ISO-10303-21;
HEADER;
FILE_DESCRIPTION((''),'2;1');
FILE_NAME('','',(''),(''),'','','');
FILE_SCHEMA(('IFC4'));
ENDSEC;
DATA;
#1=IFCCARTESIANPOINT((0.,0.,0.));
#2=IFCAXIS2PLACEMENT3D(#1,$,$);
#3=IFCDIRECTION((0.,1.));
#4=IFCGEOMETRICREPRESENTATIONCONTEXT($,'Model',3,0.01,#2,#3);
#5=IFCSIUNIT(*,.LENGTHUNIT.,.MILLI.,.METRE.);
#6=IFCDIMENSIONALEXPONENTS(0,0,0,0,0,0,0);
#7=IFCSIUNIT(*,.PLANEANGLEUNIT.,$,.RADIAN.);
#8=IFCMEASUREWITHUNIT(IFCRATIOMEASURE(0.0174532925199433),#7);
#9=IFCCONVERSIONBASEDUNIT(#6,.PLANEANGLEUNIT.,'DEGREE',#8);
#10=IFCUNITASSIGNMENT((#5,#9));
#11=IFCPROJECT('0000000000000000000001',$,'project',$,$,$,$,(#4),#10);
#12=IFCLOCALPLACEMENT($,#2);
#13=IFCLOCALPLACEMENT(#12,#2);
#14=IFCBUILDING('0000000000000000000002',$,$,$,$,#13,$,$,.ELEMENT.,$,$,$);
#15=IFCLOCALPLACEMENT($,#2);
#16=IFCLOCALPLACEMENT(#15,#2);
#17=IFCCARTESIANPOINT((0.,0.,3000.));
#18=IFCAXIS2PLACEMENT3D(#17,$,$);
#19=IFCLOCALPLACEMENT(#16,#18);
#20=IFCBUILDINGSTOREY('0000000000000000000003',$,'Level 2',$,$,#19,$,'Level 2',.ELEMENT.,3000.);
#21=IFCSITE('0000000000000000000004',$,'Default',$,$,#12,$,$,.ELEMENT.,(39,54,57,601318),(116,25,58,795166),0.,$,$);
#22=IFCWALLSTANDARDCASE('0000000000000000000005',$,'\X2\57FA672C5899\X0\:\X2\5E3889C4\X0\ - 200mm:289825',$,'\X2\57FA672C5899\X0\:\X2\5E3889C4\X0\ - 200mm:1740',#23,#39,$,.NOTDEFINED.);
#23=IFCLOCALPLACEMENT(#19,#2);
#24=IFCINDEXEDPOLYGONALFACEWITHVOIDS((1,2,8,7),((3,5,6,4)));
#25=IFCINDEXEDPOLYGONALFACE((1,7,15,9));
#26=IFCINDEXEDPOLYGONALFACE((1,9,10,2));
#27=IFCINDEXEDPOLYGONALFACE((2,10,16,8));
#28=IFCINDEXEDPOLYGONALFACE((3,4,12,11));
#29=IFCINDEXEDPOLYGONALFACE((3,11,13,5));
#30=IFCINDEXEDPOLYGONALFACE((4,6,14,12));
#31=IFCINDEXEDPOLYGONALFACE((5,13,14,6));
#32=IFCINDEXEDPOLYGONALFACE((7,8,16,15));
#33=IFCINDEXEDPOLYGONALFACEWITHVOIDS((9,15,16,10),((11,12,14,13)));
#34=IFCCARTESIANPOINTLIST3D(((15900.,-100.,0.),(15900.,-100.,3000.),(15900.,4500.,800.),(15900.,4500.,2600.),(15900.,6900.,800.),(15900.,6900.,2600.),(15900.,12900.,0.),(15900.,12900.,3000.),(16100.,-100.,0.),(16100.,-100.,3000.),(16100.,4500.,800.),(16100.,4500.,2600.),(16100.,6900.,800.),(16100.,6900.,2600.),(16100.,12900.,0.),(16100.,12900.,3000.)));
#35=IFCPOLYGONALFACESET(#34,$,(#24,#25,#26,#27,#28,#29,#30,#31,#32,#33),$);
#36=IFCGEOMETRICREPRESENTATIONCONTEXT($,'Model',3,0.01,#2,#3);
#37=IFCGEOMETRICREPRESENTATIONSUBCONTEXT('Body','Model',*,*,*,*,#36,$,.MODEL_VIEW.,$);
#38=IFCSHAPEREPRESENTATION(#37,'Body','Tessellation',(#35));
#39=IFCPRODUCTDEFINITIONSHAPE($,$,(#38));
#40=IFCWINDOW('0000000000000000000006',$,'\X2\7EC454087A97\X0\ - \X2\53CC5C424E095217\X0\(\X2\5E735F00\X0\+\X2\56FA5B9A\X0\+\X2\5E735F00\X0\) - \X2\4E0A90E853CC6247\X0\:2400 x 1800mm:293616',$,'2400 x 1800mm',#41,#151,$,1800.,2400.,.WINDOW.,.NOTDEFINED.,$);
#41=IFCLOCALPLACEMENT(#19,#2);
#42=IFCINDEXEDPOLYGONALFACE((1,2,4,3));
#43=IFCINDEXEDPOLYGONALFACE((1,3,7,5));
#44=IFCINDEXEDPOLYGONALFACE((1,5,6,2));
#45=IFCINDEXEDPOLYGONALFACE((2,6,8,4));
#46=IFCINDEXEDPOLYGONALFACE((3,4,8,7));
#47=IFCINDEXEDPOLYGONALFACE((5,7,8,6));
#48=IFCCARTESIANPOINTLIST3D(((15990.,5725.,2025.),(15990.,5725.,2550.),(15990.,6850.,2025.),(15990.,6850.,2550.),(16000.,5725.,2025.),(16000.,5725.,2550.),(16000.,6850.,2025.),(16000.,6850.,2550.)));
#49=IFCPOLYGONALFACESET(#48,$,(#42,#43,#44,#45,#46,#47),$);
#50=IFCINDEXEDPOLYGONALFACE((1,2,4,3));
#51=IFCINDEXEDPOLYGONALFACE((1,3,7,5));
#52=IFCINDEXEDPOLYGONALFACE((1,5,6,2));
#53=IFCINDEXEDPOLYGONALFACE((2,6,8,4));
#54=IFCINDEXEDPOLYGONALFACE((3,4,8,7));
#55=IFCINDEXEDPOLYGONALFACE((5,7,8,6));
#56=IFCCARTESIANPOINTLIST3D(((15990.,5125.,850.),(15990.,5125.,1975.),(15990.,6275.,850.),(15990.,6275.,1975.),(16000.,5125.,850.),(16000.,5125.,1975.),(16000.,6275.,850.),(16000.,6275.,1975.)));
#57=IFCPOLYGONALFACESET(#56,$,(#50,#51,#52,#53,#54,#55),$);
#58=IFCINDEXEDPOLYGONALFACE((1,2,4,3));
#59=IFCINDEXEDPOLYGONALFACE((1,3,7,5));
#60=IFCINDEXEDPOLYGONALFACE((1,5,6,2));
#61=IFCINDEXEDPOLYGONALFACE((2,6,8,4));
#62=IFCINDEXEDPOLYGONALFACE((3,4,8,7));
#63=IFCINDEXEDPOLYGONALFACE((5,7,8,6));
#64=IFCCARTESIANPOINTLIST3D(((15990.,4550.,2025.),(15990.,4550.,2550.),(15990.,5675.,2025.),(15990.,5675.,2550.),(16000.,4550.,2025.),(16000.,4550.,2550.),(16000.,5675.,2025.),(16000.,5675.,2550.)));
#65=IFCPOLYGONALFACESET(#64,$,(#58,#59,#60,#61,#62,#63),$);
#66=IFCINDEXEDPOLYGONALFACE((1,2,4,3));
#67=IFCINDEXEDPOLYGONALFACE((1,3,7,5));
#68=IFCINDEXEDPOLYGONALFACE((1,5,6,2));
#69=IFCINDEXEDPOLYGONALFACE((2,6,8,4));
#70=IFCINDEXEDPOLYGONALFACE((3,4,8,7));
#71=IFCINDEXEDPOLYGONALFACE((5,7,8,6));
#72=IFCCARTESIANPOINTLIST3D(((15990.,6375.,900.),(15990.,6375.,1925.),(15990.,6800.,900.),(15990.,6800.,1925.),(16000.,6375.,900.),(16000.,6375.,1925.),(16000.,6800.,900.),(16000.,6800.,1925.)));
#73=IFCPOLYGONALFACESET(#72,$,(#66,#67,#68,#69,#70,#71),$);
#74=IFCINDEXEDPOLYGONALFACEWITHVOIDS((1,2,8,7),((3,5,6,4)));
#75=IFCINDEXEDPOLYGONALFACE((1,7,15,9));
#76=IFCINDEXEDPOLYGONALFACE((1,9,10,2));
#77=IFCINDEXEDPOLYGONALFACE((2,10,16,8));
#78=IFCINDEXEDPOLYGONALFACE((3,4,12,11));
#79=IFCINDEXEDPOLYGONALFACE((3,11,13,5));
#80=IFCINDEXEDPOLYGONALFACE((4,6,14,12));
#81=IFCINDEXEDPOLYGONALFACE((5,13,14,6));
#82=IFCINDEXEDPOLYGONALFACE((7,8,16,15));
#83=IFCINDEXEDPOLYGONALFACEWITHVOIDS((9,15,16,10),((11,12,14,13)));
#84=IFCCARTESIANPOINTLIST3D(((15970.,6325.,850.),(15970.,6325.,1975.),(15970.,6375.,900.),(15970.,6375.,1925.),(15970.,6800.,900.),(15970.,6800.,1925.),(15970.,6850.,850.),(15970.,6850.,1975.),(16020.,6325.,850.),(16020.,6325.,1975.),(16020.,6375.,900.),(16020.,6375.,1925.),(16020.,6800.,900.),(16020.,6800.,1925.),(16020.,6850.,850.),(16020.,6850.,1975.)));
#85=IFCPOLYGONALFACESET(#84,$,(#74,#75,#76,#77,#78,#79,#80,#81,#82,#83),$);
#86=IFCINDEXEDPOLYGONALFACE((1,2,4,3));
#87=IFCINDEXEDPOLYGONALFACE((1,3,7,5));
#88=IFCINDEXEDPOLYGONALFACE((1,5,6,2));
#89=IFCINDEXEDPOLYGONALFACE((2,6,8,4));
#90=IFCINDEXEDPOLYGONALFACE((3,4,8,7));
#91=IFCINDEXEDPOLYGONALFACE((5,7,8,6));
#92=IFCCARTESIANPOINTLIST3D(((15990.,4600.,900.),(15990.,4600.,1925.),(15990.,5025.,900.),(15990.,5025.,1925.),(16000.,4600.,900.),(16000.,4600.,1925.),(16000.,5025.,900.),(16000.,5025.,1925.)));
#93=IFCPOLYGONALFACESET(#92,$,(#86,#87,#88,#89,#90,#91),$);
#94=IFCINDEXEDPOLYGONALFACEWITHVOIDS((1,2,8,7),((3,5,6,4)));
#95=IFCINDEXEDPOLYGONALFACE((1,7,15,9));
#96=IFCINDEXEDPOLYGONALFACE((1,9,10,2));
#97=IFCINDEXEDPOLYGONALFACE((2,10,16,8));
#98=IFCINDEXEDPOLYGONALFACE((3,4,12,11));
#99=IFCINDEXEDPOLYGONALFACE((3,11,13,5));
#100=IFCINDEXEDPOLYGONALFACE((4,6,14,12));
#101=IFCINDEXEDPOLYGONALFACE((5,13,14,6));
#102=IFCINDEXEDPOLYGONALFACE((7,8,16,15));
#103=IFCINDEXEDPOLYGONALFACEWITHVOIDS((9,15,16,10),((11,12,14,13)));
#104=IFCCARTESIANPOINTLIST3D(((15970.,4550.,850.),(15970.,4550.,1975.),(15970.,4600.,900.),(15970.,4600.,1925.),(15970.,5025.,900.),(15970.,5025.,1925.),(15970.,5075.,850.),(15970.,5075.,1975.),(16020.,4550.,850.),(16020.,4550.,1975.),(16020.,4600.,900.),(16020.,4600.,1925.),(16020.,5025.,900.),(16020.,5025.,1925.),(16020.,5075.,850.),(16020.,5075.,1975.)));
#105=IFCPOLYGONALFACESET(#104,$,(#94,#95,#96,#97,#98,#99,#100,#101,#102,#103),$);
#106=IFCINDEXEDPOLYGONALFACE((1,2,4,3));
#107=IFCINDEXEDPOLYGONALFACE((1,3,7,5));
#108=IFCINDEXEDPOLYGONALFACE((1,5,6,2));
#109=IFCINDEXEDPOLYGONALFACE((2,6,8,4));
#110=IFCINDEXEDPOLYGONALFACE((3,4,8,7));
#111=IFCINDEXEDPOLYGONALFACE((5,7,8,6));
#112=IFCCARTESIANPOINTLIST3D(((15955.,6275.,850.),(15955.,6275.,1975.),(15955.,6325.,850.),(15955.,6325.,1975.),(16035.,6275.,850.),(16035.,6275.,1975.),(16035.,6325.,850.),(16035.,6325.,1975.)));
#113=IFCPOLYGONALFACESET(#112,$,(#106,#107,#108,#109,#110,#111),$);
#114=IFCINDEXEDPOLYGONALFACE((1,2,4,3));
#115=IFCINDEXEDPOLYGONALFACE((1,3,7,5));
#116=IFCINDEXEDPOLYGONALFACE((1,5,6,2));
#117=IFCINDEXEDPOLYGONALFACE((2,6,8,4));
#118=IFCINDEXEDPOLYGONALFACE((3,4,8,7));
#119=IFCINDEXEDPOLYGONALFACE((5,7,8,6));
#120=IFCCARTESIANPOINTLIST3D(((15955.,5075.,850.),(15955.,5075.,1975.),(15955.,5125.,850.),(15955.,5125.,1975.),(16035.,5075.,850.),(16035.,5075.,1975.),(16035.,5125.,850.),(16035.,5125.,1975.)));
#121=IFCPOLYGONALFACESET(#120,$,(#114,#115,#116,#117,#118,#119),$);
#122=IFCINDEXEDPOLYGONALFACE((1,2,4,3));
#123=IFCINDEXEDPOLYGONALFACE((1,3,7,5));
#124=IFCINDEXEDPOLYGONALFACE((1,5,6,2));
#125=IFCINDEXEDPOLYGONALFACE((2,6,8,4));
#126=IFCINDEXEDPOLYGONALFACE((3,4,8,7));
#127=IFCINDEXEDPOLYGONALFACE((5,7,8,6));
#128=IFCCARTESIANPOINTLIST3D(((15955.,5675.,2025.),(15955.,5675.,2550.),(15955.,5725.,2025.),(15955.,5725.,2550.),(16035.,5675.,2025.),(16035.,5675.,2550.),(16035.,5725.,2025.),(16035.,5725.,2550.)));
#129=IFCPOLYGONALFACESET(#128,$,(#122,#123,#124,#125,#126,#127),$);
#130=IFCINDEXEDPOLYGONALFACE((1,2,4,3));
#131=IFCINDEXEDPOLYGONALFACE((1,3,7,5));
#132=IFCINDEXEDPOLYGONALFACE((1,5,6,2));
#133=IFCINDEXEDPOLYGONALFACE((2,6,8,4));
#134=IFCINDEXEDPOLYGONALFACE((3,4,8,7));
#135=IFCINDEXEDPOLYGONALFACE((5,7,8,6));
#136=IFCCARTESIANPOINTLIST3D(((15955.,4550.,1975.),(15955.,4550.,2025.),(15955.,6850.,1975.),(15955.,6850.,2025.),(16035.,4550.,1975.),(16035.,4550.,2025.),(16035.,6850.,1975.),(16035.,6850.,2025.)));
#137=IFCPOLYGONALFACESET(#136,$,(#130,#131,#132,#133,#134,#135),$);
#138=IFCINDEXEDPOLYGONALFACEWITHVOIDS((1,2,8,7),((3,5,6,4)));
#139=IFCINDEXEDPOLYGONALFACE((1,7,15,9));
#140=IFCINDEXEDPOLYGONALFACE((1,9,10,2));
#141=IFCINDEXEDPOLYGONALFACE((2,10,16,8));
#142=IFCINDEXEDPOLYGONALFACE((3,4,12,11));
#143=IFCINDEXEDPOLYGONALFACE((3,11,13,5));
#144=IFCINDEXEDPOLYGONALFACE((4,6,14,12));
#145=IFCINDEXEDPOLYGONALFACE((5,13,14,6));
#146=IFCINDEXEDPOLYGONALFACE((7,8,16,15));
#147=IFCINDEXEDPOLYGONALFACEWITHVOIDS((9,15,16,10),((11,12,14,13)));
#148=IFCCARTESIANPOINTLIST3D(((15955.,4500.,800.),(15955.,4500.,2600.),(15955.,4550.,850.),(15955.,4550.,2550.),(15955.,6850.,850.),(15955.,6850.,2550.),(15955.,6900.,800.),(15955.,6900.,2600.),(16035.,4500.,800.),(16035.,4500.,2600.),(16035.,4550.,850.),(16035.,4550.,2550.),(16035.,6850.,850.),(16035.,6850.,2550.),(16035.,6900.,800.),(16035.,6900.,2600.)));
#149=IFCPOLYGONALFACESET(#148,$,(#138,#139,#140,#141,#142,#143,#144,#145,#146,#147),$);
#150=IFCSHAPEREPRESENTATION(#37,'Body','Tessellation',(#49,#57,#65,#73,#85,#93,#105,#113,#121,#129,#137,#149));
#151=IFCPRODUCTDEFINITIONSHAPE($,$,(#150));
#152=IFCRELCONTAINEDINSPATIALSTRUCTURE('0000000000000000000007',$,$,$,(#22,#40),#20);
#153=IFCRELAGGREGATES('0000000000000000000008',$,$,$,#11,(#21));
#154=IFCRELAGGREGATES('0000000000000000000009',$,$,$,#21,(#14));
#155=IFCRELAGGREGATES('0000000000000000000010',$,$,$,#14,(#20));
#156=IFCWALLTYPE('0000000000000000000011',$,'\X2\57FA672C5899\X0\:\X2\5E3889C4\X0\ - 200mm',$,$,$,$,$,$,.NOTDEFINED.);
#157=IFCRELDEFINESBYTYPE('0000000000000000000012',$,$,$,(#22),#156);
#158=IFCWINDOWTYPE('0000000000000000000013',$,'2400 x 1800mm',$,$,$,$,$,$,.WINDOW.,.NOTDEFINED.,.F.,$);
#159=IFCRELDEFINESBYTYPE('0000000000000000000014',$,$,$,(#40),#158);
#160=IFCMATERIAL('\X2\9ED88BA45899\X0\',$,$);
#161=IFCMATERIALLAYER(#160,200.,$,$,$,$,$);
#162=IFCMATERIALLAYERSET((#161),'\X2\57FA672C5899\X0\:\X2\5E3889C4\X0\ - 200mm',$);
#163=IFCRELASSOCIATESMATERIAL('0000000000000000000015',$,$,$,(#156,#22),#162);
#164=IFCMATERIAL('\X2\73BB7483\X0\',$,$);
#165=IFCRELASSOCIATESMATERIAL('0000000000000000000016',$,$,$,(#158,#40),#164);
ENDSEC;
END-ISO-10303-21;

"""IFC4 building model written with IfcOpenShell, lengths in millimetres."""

from ifc_helpers import new_model, entity, si_unit, converted_unit, direction, frame, frame_2d, origin, origin_2d_with_axis, place, context, subcontext, project, spatial, polyline, rectangle, outline, extrude, source, transform, mapped, material, layer, layer_set, layer_usage, type_object, type_shapes, element, fill, save


model = new_model("IFC4")

# Units and contexts
model_context_1 = context("Model", 3, precision=0.01, world=origin(), true_north=direction((0.0, 1.0)))
model_context_2 = context("Model", 3, precision=0.01, world=origin(), true_north=direction((0.0, 1.0)))
body_context = subcontext(model_context_2, "Body", "Model", "MODEL_VIEW")
ifc_project = project(units=[si_unit("LENGTHUNIT", "METRE", prefix="MILLI"), converted_unit("PLANEANGLEUNIT", "DEGREE", entity("IfcRatioMeasure", 0.0174532925199433), si_unit("PLANEANGLEUNIT", "RADIAN"), dimensions=[0, 0, 0, 0, 0, 0, 0])], contexts=[model_context_1])

# Site, building, storey
site_placement = place(None, origin())
site = spatial("IfcSite", under=ifc_project, at=site_placement, Name="Default", CompositionType="ELEMENT", RefLatitude=(39, 54, 57, 601318), RefLongitude=(116, 25, 58, 795166), RefElevation=0.0)
building_placement = place(site_placement, origin())
building = spatial("IfcBuilding", under=site, at=building_placement, CompositionType="ELEMENT")
placement_1 = place(None, origin())
placement_2 = place(placement_1, origin())
storey_placement = place(placement_2, frame((0.0, 0.0, 3000.0)))
storey = spatial("IfcBuildingStorey", under=building, at=storey_placement, Name="Level 2", LongName="Level 2", CompositionType="ELEMENT", Elevation=3000.0)

# Shared definitions
ifc_material_1 = material(Name="默认墙")
ifc_layer = layer(ifc_material_1, 200.0)
ifc_layer_set = layer_set([ifc_layer], Name="基本墙:常规 - 200mm")
wall_type = type_object("IfcWallType", Name="基本墙:常规 - 200mm", PredefinedType="NOTDEFINED", material=ifc_layer_set)

# Wall, opening, window
ifc_layer_usage_1 = layer_usage(ifc_layer_set, "AXIS2", "NEGATIVE", 100.0)
wall_1_placement = place(storey_placement, frame((16000.0, 12900.0, 0.0), z_axis=(0.0, 0.0, 1.0), x_axis=(0.0, -1.0, 0.0)))
wall_1 = element("IfcWallStandardCase", 1, at=wall_1_placement, inside=storey, type_object=wall_type, material=ifc_layer_usage_1, Name="基本墙:常规 - 200mm:289825", ObjectType="基本墙:常规 - 200mm:1740", PredefinedType="NOTDEFINED", context=body_context, shape_type="SweptSolid", body=[
    extrude(rectangle(XDim=13000.0, YDim=200.0, at=frame_2d((6500.0, 0.0), x_axis=(-1.0, 0.0))), origin(), (0.0, 0.0, 1.0), 3000.0),
])
opening_1_placement = place(wall_1_placement, frame((6000.0, -100.0, 800.0)))
opening_1 = element("IfcOpeningElement", 2, at=opening_1_placement, cuts=wall_1, ObjectType="Opening", PredefinedType="OPENING", context=body_context, shape_type="SweptSolid", body=[
    extrude(rectangle(XDim=1800.0, YDim=2400.0, at=frame_2d((900.0, 1200.0), x_axis=(1.0, 0.0))), frame((0.0, 0.0, 0.0), z_axis=(0.0, 1.0, 0.0), x_axis=(0.0, 0.0, 1.0)), (0.0, 0.0, 1.0), 200.0),
])
ifc_material_2 = material(Name="玻璃")
window_type_1 = type_object("IfcWindowType", Name="2400 x 1800mm", ParameterTakesPrecedence=False, PartitioningType="NOTDEFINED", PredefinedType="WINDOW", material=ifc_material_2)
shared_shape_1 = source(origin(), body_context, "Body", "SweptSolid", [
    extrude(rectangle(XDim=10.0, YDim=1125.0, at=origin_2d_with_axis()), frame((612.5, 95.0, 1225.0), z_axis=(0.0, 0.0, 1.0), x_axis=(0.0, 1.0, 0.0)), (0.0, 0.0, 1.0), 525.0),
    extrude(rectangle(XDim=10.0, YDim=1150.0, at=origin_2d_with_axis()), frame((1200.0, 95.0, 50.0), z_axis=(0.0, 0.0, 1.0), x_axis=(0.0, 1.0, 0.0)), (0.0, 0.0, 1.0), 1125.0),
    extrude(rectangle(XDim=10.0, YDim=1125.0, at=origin_2d_with_axis()), frame((1787.5, 95.0, 1225.0), z_axis=(0.0, 0.0, 1.0), x_axis=(0.0, 1.0, 0.0)), (0.0, 0.0, 1.0), 525.0),
    extrude(rectangle(XDim=10.0, YDim=425.0, at=origin_2d_with_axis()), frame((312.5, 95.0, 100.0), z_axis=(0.0, 0.0, 1.0), x_axis=(0.0, 1.0, 0.0)), (0.0, 0.0, 1.0), 1025.0),
    extrude(outline(polyline([(-562.5, -262.5), (562.5, -262.5), (562.5, 262.5), (-562.5, 262.5), (-562.5, -262.5)]), holes=[polyline([(512.5, -212.5), (-512.5, -212.5), (-512.5, 212.5), (512.5, 212.5), (512.5, -212.5)])]), frame((312.5, 70.0, 612.5), z_axis=(0.0, 1.0, 0.0), x_axis=(0.0, 0.0, -1.0)), (0.0, 0.0, 1.0), 50.0),
    extrude(rectangle(XDim=10.0, YDim=425.0, at=frame_2d((0.0, 0.0), x_axis=(1.0, 0.0))), frame((2087.5, 95.0, 100.0), z_axis=(0.0, 0.0, 1.0), x_axis=(0.0, 1.0, 0.0)), (0.0, 0.0, 1.0), 1025.0),
    extrude(outline(polyline([(-562.5, -262.5), (562.5, -262.5), (562.5, 262.5), (-562.5, 262.5), (-562.5, -262.5)]), holes=[polyline([(512.5, -212.5), (-512.5, -212.5), (-512.5, 212.5), (512.5, 212.5), (512.5, -212.5)])]), frame((2087.5, 70.0, 612.5), z_axis=(0.0, 1.0, 0.0), x_axis=(0.0, 0.0, -1.0)), (0.0, 0.0, 1.0), 50.0),
    extrude(rectangle(XDim=80.0, YDim=50.0, at=origin_2d_with_axis()), frame((600.0, 95.0, 50.0), z_axis=(0.0, 0.0, 1.0), x_axis=(0.0, -1.0, 0.0)), (0.0, 0.0, 1.0), 1125.0),
    extrude(rectangle(XDim=80.0, YDim=50.0, at=origin_2d_with_axis()), frame((1800.0, 95.0, 50.0), z_axis=(0.0, 0.0, 1.0), x_axis=(0.0, -1.0, 0.0)), (0.0, 0.0, 1.0), 1125.0),
    extrude(rectangle(XDim=80.0, YDim=50.0, at=frame_2d((0.0, 0.0), x_axis=(1.0, 0.0))), frame((1200.0, 95.0, 1225.0), z_axis=(0.0, 0.0, 1.0), x_axis=(0.0, -1.0, 0.0)), (0.0, 0.0, 1.0), 525.0),
    extrude(rectangle(XDim=80.0, YDim=2300.0, at=frame_2d((0.0, 0.0), x_axis=(1.0, 0.0))), frame((1200.0, 95.0, 1175.0), z_axis=(0.0, 0.0, 1.0), x_axis=(0.0, -1.0, 0.0)), (0.0, 0.0, 1.0), 50.0),
    extrude(outline(polyline([(-1200.0, -900.0), (1200.0, -900.0), (1200.0, 900.0), (-1200.0, 900.0), (-1200.0, -900.0)]), holes=[polyline([(1150.0, -850.0), (-1150.0, -850.0), (-1150.0, 850.0), (1150.0, 850.0), (1150.0, -850.0)])]), frame((1200.0, 55.0, 900.0), z_axis=(0.0, 1.0, 0.0), x_axis=(1.0, 0.0, 0.0)), (0.0, 0.0, 1.0), 80.0),
])
type_shapes(window_type_1, [shared_shape_1])
window_1_placement = place(opening_1_placement, origin())
window_1 = element("IfcWindow", 3, at=window_1_placement, inside=storey, type_object=window_type_1, material=ifc_material_2, Name="组合窗 - 双层三列(平开+固定+平开) - 上部双扇:2400 x 1800mm:293616", ObjectType="2400 x 1800mm", OverallHeight=1800.0, OverallWidth=2400.0, PartitioningType="NOTDEFINED", PredefinedType="WINDOW", context=body_context, shape_type="MappedRepresentation", body=[
    mapped(shared_shape_1, transform((0.0, 0.0, 0.0), scale=1.0)),
])
fill(opening_1, window_1)

save(model, "model.ifc")
